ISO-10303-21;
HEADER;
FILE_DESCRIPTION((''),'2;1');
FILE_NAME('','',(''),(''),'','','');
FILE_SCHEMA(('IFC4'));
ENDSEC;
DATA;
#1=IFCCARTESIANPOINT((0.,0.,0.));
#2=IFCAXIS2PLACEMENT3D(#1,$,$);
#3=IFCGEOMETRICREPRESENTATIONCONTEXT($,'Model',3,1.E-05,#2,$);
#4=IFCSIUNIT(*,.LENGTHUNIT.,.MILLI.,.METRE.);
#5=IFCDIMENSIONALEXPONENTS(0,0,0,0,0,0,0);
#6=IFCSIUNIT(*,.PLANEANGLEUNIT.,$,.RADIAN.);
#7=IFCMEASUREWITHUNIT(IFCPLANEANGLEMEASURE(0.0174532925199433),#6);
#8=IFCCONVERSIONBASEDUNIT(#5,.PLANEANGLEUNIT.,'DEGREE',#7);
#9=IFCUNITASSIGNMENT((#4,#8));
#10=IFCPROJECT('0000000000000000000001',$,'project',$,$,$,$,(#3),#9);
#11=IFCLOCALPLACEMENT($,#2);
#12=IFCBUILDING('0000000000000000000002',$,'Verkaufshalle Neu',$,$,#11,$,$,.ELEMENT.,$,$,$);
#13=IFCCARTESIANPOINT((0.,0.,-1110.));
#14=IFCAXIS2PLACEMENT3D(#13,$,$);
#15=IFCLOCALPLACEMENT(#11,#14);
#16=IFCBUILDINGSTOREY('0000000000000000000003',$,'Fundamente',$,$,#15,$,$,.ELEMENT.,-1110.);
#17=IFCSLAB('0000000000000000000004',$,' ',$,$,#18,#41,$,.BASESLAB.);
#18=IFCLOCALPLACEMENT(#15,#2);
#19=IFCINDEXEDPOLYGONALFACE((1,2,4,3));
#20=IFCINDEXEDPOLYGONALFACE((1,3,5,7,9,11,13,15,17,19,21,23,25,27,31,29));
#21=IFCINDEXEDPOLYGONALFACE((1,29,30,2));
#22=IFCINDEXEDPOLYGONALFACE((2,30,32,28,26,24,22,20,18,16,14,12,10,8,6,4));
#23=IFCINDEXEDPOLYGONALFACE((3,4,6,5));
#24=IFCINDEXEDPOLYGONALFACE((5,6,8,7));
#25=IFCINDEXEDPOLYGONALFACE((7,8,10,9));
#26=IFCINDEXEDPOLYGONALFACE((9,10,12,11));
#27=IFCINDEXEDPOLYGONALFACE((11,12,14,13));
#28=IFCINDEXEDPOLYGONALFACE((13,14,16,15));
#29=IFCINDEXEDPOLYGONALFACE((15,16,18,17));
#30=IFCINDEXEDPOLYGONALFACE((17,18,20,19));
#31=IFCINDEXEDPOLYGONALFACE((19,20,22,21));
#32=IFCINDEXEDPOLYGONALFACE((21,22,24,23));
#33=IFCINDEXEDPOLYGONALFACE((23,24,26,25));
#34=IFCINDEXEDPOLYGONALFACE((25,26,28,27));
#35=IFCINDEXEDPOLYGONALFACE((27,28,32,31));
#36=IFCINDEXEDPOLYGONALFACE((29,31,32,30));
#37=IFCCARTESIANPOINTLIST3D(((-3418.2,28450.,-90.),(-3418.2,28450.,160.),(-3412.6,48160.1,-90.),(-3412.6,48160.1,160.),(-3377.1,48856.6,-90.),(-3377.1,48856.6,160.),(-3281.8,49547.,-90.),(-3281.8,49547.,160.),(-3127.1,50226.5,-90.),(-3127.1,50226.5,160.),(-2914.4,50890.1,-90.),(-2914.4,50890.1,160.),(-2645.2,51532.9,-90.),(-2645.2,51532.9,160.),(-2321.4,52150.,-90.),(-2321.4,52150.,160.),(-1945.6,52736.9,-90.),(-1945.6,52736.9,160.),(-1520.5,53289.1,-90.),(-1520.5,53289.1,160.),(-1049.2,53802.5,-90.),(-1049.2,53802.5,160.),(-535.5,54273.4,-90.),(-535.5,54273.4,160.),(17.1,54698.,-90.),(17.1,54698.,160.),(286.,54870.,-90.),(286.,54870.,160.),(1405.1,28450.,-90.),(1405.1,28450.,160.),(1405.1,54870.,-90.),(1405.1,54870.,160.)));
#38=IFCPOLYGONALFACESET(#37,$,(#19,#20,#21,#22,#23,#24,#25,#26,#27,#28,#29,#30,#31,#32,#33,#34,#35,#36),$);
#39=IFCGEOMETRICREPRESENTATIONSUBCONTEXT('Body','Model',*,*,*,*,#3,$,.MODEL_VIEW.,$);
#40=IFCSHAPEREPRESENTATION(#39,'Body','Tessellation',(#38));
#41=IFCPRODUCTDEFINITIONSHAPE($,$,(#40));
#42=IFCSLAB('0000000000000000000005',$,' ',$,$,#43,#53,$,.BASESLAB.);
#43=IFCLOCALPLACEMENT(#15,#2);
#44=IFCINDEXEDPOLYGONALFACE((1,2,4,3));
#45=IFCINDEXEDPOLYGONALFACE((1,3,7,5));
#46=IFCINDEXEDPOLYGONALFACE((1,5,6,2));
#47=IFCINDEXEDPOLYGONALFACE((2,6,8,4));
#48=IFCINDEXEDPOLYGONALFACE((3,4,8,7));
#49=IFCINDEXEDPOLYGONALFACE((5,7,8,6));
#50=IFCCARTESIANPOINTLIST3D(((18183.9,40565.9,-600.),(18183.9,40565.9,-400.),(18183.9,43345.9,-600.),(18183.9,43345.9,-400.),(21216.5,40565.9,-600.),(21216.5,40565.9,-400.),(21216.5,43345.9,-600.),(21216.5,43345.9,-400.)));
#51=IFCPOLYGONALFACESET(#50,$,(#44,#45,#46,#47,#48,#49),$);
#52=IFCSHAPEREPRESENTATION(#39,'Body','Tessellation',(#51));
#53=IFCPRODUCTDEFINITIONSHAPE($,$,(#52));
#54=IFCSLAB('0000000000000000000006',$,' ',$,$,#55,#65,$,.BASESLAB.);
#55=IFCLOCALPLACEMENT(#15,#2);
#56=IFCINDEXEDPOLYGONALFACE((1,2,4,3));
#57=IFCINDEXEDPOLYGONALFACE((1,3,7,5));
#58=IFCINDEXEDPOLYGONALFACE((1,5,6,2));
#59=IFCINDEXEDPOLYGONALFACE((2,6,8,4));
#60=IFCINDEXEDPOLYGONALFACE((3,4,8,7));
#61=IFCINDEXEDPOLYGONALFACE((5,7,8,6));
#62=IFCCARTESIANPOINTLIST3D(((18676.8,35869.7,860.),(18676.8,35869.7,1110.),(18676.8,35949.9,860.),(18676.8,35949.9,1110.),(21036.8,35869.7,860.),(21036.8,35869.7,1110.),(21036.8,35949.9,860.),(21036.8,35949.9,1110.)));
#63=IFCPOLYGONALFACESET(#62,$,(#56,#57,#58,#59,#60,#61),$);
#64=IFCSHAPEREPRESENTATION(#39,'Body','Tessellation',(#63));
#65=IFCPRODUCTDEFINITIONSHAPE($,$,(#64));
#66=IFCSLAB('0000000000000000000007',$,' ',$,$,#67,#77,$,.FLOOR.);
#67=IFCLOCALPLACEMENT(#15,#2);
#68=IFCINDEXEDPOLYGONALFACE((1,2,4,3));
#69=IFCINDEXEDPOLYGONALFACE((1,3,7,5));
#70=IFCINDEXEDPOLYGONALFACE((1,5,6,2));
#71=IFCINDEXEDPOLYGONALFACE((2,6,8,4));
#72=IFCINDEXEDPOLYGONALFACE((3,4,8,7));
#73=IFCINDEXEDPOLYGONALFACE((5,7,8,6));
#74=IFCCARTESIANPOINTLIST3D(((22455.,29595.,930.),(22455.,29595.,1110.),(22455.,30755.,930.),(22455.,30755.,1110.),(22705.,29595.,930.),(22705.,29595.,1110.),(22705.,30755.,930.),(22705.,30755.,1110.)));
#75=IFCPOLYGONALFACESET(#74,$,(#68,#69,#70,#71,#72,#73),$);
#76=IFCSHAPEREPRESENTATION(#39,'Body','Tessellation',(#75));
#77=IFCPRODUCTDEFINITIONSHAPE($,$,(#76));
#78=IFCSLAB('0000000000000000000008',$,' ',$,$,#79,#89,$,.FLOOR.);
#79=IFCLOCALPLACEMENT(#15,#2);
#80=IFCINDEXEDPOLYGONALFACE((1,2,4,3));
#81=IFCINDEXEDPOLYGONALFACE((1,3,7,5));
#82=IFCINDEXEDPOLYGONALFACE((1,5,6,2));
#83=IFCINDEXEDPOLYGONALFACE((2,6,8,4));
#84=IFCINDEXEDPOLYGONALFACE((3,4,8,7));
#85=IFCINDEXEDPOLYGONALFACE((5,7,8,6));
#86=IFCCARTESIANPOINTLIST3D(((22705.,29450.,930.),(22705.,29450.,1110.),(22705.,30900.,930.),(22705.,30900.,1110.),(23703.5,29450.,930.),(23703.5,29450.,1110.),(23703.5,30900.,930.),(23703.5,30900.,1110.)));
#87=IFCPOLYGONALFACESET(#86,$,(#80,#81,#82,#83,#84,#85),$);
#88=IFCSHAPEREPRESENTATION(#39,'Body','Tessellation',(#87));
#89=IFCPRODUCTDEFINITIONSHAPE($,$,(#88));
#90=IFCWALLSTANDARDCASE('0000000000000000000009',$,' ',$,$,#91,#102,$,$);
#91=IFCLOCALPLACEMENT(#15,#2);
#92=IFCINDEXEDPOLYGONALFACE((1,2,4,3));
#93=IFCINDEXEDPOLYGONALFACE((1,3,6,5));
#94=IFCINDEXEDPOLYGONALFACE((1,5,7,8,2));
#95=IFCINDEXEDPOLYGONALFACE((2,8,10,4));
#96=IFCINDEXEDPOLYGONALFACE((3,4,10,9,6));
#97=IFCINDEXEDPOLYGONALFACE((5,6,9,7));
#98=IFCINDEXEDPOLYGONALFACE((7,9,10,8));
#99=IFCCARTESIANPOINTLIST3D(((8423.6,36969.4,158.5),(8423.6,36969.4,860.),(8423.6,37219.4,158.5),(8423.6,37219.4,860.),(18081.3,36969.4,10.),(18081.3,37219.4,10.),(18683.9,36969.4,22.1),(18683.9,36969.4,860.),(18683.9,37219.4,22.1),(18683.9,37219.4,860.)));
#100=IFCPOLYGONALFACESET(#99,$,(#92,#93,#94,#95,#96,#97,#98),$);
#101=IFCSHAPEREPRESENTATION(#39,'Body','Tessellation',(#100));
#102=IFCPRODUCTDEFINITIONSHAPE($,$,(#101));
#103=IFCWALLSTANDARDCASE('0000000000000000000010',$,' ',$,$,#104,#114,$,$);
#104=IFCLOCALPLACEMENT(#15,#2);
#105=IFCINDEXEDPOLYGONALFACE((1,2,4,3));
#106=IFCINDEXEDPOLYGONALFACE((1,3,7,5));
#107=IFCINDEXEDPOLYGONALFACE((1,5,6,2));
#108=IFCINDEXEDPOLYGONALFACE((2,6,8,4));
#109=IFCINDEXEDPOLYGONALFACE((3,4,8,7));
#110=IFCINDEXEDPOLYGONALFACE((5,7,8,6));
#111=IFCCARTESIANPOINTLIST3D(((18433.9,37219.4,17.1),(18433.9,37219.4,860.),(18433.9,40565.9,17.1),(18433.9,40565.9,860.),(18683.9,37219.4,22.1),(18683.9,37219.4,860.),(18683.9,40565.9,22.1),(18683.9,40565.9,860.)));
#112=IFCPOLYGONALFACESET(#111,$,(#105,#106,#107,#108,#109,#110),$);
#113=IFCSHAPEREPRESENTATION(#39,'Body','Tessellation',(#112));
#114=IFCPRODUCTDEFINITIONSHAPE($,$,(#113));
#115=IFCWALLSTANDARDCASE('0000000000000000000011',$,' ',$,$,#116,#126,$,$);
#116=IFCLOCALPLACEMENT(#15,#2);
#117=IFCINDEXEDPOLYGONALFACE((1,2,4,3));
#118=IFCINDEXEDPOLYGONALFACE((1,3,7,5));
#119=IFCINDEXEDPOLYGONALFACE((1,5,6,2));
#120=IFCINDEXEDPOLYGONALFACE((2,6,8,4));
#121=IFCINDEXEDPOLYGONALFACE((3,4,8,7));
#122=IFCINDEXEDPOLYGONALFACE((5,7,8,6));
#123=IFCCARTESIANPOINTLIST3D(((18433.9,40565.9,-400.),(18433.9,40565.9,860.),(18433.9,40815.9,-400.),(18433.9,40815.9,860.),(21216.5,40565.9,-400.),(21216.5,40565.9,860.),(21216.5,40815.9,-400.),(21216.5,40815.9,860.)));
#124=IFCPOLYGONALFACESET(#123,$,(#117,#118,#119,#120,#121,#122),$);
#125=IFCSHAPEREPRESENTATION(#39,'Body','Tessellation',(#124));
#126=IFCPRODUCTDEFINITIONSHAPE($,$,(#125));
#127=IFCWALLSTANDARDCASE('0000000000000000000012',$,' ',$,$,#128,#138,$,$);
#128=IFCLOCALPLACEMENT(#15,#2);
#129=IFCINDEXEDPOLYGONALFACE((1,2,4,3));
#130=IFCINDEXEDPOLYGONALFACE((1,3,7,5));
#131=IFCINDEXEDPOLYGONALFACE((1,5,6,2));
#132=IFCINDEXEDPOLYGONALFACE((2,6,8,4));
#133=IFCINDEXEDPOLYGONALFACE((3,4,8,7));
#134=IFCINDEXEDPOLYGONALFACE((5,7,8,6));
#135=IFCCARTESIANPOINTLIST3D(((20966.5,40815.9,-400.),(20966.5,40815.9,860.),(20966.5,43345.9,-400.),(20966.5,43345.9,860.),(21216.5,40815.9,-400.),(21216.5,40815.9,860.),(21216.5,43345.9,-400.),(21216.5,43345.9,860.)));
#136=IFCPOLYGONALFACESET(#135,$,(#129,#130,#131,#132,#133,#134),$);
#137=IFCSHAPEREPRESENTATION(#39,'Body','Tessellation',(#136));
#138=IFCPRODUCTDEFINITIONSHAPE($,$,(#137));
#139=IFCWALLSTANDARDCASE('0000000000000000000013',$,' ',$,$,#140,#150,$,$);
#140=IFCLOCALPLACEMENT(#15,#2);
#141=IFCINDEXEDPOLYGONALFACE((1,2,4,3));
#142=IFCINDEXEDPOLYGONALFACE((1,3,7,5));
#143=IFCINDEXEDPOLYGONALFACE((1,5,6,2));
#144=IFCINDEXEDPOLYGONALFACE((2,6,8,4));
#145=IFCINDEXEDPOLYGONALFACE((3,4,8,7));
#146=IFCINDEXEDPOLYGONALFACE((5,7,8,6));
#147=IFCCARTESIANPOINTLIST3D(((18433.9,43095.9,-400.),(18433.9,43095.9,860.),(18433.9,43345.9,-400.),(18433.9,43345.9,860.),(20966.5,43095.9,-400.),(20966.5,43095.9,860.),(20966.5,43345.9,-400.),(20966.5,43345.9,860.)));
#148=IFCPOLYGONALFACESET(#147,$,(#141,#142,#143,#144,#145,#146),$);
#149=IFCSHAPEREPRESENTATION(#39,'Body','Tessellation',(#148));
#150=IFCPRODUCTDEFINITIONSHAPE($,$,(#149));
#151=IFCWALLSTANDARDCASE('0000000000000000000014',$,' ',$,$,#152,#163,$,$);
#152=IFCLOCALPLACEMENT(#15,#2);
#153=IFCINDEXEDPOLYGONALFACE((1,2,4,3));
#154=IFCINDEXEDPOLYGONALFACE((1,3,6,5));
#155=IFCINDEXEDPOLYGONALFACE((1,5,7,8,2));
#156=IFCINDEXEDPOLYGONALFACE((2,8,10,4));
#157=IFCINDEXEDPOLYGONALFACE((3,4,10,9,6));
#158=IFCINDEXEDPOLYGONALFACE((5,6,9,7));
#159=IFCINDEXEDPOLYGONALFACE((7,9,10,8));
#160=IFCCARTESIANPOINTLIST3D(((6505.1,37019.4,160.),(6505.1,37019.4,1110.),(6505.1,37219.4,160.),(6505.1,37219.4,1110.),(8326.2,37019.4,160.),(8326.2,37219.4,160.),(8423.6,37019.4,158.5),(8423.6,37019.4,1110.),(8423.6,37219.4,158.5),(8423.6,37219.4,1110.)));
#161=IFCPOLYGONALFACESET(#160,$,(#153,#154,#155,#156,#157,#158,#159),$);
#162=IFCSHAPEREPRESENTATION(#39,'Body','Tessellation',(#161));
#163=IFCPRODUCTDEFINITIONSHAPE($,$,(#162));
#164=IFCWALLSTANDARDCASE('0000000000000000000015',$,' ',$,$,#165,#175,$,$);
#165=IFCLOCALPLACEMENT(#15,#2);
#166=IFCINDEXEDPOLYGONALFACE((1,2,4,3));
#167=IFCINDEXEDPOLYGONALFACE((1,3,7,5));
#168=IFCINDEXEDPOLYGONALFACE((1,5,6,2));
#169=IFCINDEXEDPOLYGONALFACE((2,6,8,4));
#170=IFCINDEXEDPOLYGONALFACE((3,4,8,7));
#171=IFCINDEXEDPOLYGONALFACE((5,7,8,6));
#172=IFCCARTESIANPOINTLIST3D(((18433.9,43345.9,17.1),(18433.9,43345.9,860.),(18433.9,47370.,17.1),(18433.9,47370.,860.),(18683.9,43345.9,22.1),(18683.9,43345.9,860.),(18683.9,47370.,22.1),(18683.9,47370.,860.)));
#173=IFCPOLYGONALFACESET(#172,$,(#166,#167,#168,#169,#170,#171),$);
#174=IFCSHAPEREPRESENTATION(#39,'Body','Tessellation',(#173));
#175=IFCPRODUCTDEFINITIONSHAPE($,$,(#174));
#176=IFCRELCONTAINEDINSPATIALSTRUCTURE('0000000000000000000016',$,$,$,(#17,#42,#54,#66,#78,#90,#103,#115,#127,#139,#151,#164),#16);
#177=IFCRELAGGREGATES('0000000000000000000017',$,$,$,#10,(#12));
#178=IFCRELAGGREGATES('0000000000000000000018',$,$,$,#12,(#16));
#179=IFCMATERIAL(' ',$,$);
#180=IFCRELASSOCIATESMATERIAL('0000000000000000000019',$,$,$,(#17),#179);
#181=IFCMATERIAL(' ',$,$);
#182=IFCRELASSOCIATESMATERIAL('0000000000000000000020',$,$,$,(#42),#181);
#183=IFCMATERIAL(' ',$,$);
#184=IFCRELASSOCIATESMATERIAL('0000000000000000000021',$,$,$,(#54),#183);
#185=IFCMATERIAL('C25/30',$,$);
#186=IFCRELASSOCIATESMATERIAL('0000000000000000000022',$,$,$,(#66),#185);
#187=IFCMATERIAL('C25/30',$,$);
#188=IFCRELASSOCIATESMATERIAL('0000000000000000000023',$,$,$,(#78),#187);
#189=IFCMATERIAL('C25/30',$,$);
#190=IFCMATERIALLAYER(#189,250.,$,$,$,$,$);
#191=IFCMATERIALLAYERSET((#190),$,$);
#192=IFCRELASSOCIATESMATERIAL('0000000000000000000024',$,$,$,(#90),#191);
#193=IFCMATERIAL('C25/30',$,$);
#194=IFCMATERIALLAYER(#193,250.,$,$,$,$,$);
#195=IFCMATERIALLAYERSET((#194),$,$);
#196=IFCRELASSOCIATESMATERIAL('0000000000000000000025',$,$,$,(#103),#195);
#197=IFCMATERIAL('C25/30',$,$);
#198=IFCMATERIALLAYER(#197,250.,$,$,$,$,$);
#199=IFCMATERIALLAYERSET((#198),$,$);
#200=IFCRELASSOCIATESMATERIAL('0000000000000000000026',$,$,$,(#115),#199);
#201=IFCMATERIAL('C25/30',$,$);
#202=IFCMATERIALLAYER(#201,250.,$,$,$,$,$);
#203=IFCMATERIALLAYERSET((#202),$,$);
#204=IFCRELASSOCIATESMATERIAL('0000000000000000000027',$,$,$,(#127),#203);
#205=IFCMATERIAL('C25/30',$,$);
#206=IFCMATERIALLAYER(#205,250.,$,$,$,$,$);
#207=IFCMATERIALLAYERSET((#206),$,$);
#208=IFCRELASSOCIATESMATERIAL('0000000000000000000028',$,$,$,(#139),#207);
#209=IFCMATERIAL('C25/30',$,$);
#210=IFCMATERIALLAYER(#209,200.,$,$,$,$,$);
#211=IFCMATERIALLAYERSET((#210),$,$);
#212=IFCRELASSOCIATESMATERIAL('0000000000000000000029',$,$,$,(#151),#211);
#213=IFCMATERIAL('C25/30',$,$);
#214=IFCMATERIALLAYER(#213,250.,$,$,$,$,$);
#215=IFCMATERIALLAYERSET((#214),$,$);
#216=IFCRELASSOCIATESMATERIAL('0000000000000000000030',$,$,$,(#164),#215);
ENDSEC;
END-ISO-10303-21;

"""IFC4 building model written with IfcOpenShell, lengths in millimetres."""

from ifc_helpers import new_model, entity, si_unit, converted_unit, frame, frame_2d, origin, origin_with_axes, place, context, subcontext, project, spatial, polyline, rectangle, outline, extrude, clip, halfspace, bounded_halfspace, material, layer, layer_set, layer_usage, element, save


model = new_model("IFC4")

# Units and contexts
model_context = context("Model", 3, precision=1e-05, world=origin())
body_context = subcontext(model_context, "Body", "Model", "MODEL_VIEW")
ifc_project = project(units=[si_unit("LENGTHUNIT", "METRE", prefix="MILLI"), converted_unit("PLANEANGLEUNIT", "DEGREE", entity("IfcPlaneAngleMeasure", 0.0174532925199433), si_unit("PLANEANGLEUNIT", "RADIAN"), dimensions=[0, 0, 0, 0, 0, 0, 0])], contexts=[model_context])

# Building, storey
building_placement = place(None, origin())
building = spatial("IfcBuilding", under=ifc_project, at=building_placement, Name="Verkaufshalle Neu", CompositionType="ELEMENT")
storey_placement = place(building_placement, frame((0.0, 0.0, -1110.0)))
storey = spatial("IfcBuildingStorey", under=building, at=storey_placement, Name="Fundamente", CompositionType="ELEMENT", Elevation=-1110.0)

# Slab
ifc_material_1 = material(Name=" ")
slab_1_placement = place(storey_placement, frame((-3418.2, 28450.0, -90.0)))
element("IfcSlab", 1, at=slab_1_placement, inside=storey, material=ifc_material_1, Name=" ", PredefinedType="BASESLAB", context=body_context, shape_type="SweptSolid", body=[
    extrude(outline(polyline([(3435.2, 26248.0), (2882.7, 25823.4), (2368.9, 25352.5), (1897.7, 24839.1), (1472.6, 24286.9), (1096.8, 23700.0), (773.0, 23082.9), (503.8, 22440.1), (291.0, 21776.5), (136.4, 21097.0), (41.0, 20406.6), (5.6, 19710.1), (0.0, 0.0), (4823.3, 0.0), (4823.3, 26420.0), (3704.2, 26420.0), (3435.2, 26248.0)])), origin_with_axes(), (0.0, 0.0, 1.0), 250.0),
])

# Slabs
ifc_material_2 = material(Name=" ")
slab_2_placement = place(storey_placement, frame((18183.9, 40565.9, -600.0)))
element("IfcSlab", 2, at=slab_2_placement, inside=storey, material=ifc_material_2, Name=" ", PredefinedType="BASESLAB", context=body_context, shape_type="SweptSolid", body=[
    extrude(rectangle(XDim=3032.6, YDim=2780.0, at=frame_2d((1516.3, 1390.0), x_axis=(1.0, 0.0))), origin_with_axes(), (0.0, 0.0, 1.0), 200.0),
])
ifc_material_3 = material(Name=" ")
slab_3_placement = place(storey_placement, frame((18676.8, 35869.7, 860.0)))
element("IfcSlab", 3, at=slab_3_placement, inside=storey, material=ifc_material_3, Name=" ", PredefinedType="BASESLAB", context=body_context, shape_type="SweptSolid", body=[
    extrude(rectangle(XDim=2360.0, YDim=80.2, at=frame_2d((-1180.0, -40.1), x_axis=(-1.0, 0.0))), frame((2360.0, 80.2, 0.0), z_axis=(0.0, 0.0, 1.0), x_axis=(1.0, 0.0, 0.0)), (0.0, 0.0, 1.0), 250.0),
])
ifc_material_4 = material(Name="C25/30")
slab_4_placement = place(storey_placement, frame((22455.0, 29595.0, 930.0)))
element("IfcSlab", 4, at=slab_4_placement, inside=storey, material=ifc_material_4, Name=" ", PredefinedType="FLOOR", context=body_context, shape_type="SweptSolid", body=[
    extrude(rectangle(XDim=1160.0, YDim=250.0, at=frame_2d((-125.0, 580.0), x_axis=(0.0, 1.0))), frame((250.0, 0.0, 0.0), z_axis=(0.0, 0.0, 1.0), x_axis=(1.0, 0.0, 0.0)), (0.0, 0.0, 1.0), 180.0),
])
ifc_material_5 = material(Name="C25/30")
slab_5_placement = place(storey_placement, frame((22705.0, 29450.0, 930.0)))
element("IfcSlab", 5, at=slab_5_placement, inside=storey, material=ifc_material_5, Name=" ", PredefinedType="FLOOR", context=body_context, shape_type="SweptSolid", body=[
    extrude(rectangle(XDim=1450.0, YDim=998.5, at=frame_2d((499.3, -725.0), x_axis=(0.0, -1.0))), frame((0.0, 1450.0, 0.0), z_axis=(0.0, 0.0, 1.0), x_axis=(1.0, 0.0, 0.0)), (0.0, 0.0, 1.0), 180.0),
])

# Walls
ifc_material_6 = material(Name="C25/30")
ifc_layer_1 = layer(ifc_material_6, 250.0)
ifc_layer_set_1 = layer_set([ifc_layer_1])
ifc_layer_usage_1 = layer_usage(ifc_layer_set_1, "AXIS2", "POSITIVE", 0.0)
wall_1_placement = place(storey_placement, frame((8423.6, 36969.4, 10.0)))
element("IfcWallStandardCase", 6, at=wall_1_placement, inside=storey, material=ifc_layer_usage_1, Name=" ", context=body_context, shape_type="Clipping", body=[
    clip(clip(extrude(rectangle(XDim=10260.3, YDim=250.0, at=frame_2d((5130.1, 125.0), x_axis=(1.0, 0.0))), origin_with_axes(), (0.0, 0.0, 1.0), 850.0), bounded_halfspace(frame((9959.0, 125.0, 6.0), z_axis=(-0.019996, 0.0, 0.9998), x_axis=(0.0, 1.0, 0.0)), True, origin_with_axes(), polyline([(10260.3, 0.0), (10260.3, 250.0), (9657.7, 250.0), (9657.7, 0.0), (10260.3, 0.0)]))), bounded_halfspace(frame((4828.8, 125.0, 74.3), z_axis=(0.015375, 0.0, 0.999882), x_axis=(0.0, -1.0, 0.0)), True, origin_with_axes(), polyline([(0.0, 250.0), (0.0, 0.0), (9657.7, 0.0), (9657.7, 250.0), (0.0, 250.0)]))),
])
ifc_material_7 = material(Name="C25/30")
ifc_layer_2 = layer(ifc_material_7, 250.0)
ifc_layer_set_2 = layer_set([ifc_layer_2])
ifc_layer_usage_2 = layer_usage(ifc_layer_set_2, "AXIS2", "POSITIVE", 0.0)
wall_2_placement = place(storey_placement, frame((18683.9, 37219.4, 17.1), z_axis=(0.0, 0.0, 1.0), x_axis=(0.0, 1.0, 0.0)))
element("IfcWallStandardCase", 7, at=wall_2_placement, inside=storey, material=ifc_layer_usage_2, Name=" ", context=body_context, shape_type="Clipping", body=[
    clip(extrude(rectangle(XDim=3346.5, YDim=250.0, at=frame_2d((1673.2, 125.0), x_axis=(1.0, 0.0))), origin_with_axes(), (0.0, 0.0, 1.0), 842.9), halfspace(frame((1673.2, 125.0, 2.5), z_axis=(0.0, 0.019996, 0.9998), x_axis=(0.0, -0.9998, 0.019996)), True)),
])
ifc_material_8 = material(Name="C25/30")
ifc_layer_3 = layer(ifc_material_8, 250.0)
ifc_layer_set_3 = layer_set([ifc_layer_3])
ifc_layer_usage_3 = layer_usage(ifc_layer_set_3, "AXIS2", "POSITIVE", 0.0)
wall_3_placement = place(storey_placement, frame((18433.9, 40565.9, -400.0)))
element("IfcWallStandardCase", 8, at=wall_3_placement, inside=storey, material=ifc_layer_usage_3, Name=" ", context=body_context, shape_type="SweptSolid", body=[
    extrude(rectangle(XDim=2782.6, YDim=250.0, at=frame_2d((1391.3, 125.0), x_axis=(1.0, 0.0))), origin_with_axes(), (0.0, 0.0, 1.0), 1260.0),
])
ifc_material_9 = material(Name="C25/30")
ifc_layer_4 = layer(ifc_material_9, 250.0)
ifc_layer_set_4 = layer_set([ifc_layer_4])
ifc_layer_usage_4 = layer_usage(ifc_layer_set_4, "AXIS2", "POSITIVE", 0.0)
wall_4_placement = place(storey_placement, frame((21216.5, 40815.9, -400.0), z_axis=(0.0, 0.0, 1.0), x_axis=(0.0, 1.0, 0.0)))
element("IfcWallStandardCase", 9, at=wall_4_placement, inside=storey, material=ifc_layer_usage_4, Name=" ", context=body_context, shape_type="SweptSolid", body=[
    extrude(rectangle(XDim=2530.0, YDim=250.0, at=frame_2d((1265.0, 125.0), x_axis=(1.0, 0.0))), origin_with_axes(), (0.0, 0.0, 1.0), 1260.0),
])
ifc_material_10 = material(Name="C25/30")
ifc_layer_5 = layer(ifc_material_10, 250.0)
ifc_layer_set_5 = layer_set([ifc_layer_5])
ifc_layer_usage_5 = layer_usage(ifc_layer_set_5, "AXIS2", "POSITIVE", 0.0)
wall_5_placement = place(storey_placement, frame((20966.5, 43345.9, -400.0), z_axis=(0.0, 0.0, 1.0), x_axis=(-1.0, 0.0, 0.0)))
element("IfcWallStandardCase", 10, at=wall_5_placement, inside=storey, material=ifc_layer_usage_5, Name=" ", context=body_context, shape_type="SweptSolid", body=[
    extrude(rectangle(XDim=2532.6, YDim=250.0, at=frame_2d((1266.3, 125.0), x_axis=(1.0, 0.0))), origin_with_axes(), (0.0, 0.0, 1.0), 1260.0),
])
ifc_material_11 = material(Name="C25/30")
ifc_layer_6 = layer(ifc_material_11, 200.0)
ifc_layer_set_6 = layer_set([ifc_layer_6])
ifc_layer_usage_6 = layer_usage(ifc_layer_set_6, "AXIS2", "POSITIVE", 0.0)
wall_6_placement = place(storey_placement, frame((8423.6, 37219.4, 158.5), z_axis=(0.0, 0.0, 1.0), x_axis=(-1.0, 0.0, 0.0)))
element("IfcWallStandardCase", 11, at=wall_6_placement, inside=storey, material=ifc_layer_usage_6, Name=" ", context=body_context, shape_type="Clipping", body=[
    clip(clip(extrude(rectangle(XDim=1918.5, YDim=200.0, at=frame_2d((959.3, 100.0), x_axis=(1.0, 0.0))), origin_with_axes(), (0.0, 0.0, 1.0), 951.5), bounded_halfspace(frame((48.7, 100.0, 0.7), z_axis=(-0.015375, 0.0, 0.999882), x_axis=(0.0, -1.0, 0.0)), True, origin_with_axes(), polyline([(0.0, 200.0), (0.0, 0.0), (97.4, 0.0), (97.4, 200.0), (0.0, 200.0)]))), bounded_halfspace(frame((1008.0, 100.0, 1.5), z_axis=(0.0, 0.0, 1.0), x_axis=(-1.0, 0.0, 0.0)), True, origin_with_axes(), polyline([(1918.5, 200.0), (97.4, 200.0), (97.4, 0.0), (1918.5, 0.0), (1918.5, 200.0)]))),
])
ifc_material_12 = material(Name="C25/30")
ifc_layer_7 = layer(ifc_material_12, 250.0)
ifc_layer_set_7 = layer_set([ifc_layer_7])
ifc_layer_usage_7 = layer_usage(ifc_layer_set_7, "AXIS2", "POSITIVE", 0.0)
wall_7_placement = place(storey_placement, frame((18683.9, 43345.9, 17.1), z_axis=(0.0, 0.0, 1.0), x_axis=(0.0, 1.0, 0.0)))
element("IfcWallStandardCase", 12, at=wall_7_placement, inside=storey, material=ifc_layer_usage_7, Name=" ", context=body_context, shape_type="Clipping", body=[
    clip(extrude(rectangle(XDim=4024.1, YDim=250.0, at=frame_2d((2012.1, 125.0), x_axis=(1.0, 0.0))), origin_with_axes(), (0.0, 0.0, 1.0), 842.9), halfspace(frame((2012.1, 125.0, 2.5), z_axis=(0.0, 0.019996, 0.9998), x_axis=(0.0, -0.9998, 0.019996)), True)),
])

save(model, "model.ifc")
